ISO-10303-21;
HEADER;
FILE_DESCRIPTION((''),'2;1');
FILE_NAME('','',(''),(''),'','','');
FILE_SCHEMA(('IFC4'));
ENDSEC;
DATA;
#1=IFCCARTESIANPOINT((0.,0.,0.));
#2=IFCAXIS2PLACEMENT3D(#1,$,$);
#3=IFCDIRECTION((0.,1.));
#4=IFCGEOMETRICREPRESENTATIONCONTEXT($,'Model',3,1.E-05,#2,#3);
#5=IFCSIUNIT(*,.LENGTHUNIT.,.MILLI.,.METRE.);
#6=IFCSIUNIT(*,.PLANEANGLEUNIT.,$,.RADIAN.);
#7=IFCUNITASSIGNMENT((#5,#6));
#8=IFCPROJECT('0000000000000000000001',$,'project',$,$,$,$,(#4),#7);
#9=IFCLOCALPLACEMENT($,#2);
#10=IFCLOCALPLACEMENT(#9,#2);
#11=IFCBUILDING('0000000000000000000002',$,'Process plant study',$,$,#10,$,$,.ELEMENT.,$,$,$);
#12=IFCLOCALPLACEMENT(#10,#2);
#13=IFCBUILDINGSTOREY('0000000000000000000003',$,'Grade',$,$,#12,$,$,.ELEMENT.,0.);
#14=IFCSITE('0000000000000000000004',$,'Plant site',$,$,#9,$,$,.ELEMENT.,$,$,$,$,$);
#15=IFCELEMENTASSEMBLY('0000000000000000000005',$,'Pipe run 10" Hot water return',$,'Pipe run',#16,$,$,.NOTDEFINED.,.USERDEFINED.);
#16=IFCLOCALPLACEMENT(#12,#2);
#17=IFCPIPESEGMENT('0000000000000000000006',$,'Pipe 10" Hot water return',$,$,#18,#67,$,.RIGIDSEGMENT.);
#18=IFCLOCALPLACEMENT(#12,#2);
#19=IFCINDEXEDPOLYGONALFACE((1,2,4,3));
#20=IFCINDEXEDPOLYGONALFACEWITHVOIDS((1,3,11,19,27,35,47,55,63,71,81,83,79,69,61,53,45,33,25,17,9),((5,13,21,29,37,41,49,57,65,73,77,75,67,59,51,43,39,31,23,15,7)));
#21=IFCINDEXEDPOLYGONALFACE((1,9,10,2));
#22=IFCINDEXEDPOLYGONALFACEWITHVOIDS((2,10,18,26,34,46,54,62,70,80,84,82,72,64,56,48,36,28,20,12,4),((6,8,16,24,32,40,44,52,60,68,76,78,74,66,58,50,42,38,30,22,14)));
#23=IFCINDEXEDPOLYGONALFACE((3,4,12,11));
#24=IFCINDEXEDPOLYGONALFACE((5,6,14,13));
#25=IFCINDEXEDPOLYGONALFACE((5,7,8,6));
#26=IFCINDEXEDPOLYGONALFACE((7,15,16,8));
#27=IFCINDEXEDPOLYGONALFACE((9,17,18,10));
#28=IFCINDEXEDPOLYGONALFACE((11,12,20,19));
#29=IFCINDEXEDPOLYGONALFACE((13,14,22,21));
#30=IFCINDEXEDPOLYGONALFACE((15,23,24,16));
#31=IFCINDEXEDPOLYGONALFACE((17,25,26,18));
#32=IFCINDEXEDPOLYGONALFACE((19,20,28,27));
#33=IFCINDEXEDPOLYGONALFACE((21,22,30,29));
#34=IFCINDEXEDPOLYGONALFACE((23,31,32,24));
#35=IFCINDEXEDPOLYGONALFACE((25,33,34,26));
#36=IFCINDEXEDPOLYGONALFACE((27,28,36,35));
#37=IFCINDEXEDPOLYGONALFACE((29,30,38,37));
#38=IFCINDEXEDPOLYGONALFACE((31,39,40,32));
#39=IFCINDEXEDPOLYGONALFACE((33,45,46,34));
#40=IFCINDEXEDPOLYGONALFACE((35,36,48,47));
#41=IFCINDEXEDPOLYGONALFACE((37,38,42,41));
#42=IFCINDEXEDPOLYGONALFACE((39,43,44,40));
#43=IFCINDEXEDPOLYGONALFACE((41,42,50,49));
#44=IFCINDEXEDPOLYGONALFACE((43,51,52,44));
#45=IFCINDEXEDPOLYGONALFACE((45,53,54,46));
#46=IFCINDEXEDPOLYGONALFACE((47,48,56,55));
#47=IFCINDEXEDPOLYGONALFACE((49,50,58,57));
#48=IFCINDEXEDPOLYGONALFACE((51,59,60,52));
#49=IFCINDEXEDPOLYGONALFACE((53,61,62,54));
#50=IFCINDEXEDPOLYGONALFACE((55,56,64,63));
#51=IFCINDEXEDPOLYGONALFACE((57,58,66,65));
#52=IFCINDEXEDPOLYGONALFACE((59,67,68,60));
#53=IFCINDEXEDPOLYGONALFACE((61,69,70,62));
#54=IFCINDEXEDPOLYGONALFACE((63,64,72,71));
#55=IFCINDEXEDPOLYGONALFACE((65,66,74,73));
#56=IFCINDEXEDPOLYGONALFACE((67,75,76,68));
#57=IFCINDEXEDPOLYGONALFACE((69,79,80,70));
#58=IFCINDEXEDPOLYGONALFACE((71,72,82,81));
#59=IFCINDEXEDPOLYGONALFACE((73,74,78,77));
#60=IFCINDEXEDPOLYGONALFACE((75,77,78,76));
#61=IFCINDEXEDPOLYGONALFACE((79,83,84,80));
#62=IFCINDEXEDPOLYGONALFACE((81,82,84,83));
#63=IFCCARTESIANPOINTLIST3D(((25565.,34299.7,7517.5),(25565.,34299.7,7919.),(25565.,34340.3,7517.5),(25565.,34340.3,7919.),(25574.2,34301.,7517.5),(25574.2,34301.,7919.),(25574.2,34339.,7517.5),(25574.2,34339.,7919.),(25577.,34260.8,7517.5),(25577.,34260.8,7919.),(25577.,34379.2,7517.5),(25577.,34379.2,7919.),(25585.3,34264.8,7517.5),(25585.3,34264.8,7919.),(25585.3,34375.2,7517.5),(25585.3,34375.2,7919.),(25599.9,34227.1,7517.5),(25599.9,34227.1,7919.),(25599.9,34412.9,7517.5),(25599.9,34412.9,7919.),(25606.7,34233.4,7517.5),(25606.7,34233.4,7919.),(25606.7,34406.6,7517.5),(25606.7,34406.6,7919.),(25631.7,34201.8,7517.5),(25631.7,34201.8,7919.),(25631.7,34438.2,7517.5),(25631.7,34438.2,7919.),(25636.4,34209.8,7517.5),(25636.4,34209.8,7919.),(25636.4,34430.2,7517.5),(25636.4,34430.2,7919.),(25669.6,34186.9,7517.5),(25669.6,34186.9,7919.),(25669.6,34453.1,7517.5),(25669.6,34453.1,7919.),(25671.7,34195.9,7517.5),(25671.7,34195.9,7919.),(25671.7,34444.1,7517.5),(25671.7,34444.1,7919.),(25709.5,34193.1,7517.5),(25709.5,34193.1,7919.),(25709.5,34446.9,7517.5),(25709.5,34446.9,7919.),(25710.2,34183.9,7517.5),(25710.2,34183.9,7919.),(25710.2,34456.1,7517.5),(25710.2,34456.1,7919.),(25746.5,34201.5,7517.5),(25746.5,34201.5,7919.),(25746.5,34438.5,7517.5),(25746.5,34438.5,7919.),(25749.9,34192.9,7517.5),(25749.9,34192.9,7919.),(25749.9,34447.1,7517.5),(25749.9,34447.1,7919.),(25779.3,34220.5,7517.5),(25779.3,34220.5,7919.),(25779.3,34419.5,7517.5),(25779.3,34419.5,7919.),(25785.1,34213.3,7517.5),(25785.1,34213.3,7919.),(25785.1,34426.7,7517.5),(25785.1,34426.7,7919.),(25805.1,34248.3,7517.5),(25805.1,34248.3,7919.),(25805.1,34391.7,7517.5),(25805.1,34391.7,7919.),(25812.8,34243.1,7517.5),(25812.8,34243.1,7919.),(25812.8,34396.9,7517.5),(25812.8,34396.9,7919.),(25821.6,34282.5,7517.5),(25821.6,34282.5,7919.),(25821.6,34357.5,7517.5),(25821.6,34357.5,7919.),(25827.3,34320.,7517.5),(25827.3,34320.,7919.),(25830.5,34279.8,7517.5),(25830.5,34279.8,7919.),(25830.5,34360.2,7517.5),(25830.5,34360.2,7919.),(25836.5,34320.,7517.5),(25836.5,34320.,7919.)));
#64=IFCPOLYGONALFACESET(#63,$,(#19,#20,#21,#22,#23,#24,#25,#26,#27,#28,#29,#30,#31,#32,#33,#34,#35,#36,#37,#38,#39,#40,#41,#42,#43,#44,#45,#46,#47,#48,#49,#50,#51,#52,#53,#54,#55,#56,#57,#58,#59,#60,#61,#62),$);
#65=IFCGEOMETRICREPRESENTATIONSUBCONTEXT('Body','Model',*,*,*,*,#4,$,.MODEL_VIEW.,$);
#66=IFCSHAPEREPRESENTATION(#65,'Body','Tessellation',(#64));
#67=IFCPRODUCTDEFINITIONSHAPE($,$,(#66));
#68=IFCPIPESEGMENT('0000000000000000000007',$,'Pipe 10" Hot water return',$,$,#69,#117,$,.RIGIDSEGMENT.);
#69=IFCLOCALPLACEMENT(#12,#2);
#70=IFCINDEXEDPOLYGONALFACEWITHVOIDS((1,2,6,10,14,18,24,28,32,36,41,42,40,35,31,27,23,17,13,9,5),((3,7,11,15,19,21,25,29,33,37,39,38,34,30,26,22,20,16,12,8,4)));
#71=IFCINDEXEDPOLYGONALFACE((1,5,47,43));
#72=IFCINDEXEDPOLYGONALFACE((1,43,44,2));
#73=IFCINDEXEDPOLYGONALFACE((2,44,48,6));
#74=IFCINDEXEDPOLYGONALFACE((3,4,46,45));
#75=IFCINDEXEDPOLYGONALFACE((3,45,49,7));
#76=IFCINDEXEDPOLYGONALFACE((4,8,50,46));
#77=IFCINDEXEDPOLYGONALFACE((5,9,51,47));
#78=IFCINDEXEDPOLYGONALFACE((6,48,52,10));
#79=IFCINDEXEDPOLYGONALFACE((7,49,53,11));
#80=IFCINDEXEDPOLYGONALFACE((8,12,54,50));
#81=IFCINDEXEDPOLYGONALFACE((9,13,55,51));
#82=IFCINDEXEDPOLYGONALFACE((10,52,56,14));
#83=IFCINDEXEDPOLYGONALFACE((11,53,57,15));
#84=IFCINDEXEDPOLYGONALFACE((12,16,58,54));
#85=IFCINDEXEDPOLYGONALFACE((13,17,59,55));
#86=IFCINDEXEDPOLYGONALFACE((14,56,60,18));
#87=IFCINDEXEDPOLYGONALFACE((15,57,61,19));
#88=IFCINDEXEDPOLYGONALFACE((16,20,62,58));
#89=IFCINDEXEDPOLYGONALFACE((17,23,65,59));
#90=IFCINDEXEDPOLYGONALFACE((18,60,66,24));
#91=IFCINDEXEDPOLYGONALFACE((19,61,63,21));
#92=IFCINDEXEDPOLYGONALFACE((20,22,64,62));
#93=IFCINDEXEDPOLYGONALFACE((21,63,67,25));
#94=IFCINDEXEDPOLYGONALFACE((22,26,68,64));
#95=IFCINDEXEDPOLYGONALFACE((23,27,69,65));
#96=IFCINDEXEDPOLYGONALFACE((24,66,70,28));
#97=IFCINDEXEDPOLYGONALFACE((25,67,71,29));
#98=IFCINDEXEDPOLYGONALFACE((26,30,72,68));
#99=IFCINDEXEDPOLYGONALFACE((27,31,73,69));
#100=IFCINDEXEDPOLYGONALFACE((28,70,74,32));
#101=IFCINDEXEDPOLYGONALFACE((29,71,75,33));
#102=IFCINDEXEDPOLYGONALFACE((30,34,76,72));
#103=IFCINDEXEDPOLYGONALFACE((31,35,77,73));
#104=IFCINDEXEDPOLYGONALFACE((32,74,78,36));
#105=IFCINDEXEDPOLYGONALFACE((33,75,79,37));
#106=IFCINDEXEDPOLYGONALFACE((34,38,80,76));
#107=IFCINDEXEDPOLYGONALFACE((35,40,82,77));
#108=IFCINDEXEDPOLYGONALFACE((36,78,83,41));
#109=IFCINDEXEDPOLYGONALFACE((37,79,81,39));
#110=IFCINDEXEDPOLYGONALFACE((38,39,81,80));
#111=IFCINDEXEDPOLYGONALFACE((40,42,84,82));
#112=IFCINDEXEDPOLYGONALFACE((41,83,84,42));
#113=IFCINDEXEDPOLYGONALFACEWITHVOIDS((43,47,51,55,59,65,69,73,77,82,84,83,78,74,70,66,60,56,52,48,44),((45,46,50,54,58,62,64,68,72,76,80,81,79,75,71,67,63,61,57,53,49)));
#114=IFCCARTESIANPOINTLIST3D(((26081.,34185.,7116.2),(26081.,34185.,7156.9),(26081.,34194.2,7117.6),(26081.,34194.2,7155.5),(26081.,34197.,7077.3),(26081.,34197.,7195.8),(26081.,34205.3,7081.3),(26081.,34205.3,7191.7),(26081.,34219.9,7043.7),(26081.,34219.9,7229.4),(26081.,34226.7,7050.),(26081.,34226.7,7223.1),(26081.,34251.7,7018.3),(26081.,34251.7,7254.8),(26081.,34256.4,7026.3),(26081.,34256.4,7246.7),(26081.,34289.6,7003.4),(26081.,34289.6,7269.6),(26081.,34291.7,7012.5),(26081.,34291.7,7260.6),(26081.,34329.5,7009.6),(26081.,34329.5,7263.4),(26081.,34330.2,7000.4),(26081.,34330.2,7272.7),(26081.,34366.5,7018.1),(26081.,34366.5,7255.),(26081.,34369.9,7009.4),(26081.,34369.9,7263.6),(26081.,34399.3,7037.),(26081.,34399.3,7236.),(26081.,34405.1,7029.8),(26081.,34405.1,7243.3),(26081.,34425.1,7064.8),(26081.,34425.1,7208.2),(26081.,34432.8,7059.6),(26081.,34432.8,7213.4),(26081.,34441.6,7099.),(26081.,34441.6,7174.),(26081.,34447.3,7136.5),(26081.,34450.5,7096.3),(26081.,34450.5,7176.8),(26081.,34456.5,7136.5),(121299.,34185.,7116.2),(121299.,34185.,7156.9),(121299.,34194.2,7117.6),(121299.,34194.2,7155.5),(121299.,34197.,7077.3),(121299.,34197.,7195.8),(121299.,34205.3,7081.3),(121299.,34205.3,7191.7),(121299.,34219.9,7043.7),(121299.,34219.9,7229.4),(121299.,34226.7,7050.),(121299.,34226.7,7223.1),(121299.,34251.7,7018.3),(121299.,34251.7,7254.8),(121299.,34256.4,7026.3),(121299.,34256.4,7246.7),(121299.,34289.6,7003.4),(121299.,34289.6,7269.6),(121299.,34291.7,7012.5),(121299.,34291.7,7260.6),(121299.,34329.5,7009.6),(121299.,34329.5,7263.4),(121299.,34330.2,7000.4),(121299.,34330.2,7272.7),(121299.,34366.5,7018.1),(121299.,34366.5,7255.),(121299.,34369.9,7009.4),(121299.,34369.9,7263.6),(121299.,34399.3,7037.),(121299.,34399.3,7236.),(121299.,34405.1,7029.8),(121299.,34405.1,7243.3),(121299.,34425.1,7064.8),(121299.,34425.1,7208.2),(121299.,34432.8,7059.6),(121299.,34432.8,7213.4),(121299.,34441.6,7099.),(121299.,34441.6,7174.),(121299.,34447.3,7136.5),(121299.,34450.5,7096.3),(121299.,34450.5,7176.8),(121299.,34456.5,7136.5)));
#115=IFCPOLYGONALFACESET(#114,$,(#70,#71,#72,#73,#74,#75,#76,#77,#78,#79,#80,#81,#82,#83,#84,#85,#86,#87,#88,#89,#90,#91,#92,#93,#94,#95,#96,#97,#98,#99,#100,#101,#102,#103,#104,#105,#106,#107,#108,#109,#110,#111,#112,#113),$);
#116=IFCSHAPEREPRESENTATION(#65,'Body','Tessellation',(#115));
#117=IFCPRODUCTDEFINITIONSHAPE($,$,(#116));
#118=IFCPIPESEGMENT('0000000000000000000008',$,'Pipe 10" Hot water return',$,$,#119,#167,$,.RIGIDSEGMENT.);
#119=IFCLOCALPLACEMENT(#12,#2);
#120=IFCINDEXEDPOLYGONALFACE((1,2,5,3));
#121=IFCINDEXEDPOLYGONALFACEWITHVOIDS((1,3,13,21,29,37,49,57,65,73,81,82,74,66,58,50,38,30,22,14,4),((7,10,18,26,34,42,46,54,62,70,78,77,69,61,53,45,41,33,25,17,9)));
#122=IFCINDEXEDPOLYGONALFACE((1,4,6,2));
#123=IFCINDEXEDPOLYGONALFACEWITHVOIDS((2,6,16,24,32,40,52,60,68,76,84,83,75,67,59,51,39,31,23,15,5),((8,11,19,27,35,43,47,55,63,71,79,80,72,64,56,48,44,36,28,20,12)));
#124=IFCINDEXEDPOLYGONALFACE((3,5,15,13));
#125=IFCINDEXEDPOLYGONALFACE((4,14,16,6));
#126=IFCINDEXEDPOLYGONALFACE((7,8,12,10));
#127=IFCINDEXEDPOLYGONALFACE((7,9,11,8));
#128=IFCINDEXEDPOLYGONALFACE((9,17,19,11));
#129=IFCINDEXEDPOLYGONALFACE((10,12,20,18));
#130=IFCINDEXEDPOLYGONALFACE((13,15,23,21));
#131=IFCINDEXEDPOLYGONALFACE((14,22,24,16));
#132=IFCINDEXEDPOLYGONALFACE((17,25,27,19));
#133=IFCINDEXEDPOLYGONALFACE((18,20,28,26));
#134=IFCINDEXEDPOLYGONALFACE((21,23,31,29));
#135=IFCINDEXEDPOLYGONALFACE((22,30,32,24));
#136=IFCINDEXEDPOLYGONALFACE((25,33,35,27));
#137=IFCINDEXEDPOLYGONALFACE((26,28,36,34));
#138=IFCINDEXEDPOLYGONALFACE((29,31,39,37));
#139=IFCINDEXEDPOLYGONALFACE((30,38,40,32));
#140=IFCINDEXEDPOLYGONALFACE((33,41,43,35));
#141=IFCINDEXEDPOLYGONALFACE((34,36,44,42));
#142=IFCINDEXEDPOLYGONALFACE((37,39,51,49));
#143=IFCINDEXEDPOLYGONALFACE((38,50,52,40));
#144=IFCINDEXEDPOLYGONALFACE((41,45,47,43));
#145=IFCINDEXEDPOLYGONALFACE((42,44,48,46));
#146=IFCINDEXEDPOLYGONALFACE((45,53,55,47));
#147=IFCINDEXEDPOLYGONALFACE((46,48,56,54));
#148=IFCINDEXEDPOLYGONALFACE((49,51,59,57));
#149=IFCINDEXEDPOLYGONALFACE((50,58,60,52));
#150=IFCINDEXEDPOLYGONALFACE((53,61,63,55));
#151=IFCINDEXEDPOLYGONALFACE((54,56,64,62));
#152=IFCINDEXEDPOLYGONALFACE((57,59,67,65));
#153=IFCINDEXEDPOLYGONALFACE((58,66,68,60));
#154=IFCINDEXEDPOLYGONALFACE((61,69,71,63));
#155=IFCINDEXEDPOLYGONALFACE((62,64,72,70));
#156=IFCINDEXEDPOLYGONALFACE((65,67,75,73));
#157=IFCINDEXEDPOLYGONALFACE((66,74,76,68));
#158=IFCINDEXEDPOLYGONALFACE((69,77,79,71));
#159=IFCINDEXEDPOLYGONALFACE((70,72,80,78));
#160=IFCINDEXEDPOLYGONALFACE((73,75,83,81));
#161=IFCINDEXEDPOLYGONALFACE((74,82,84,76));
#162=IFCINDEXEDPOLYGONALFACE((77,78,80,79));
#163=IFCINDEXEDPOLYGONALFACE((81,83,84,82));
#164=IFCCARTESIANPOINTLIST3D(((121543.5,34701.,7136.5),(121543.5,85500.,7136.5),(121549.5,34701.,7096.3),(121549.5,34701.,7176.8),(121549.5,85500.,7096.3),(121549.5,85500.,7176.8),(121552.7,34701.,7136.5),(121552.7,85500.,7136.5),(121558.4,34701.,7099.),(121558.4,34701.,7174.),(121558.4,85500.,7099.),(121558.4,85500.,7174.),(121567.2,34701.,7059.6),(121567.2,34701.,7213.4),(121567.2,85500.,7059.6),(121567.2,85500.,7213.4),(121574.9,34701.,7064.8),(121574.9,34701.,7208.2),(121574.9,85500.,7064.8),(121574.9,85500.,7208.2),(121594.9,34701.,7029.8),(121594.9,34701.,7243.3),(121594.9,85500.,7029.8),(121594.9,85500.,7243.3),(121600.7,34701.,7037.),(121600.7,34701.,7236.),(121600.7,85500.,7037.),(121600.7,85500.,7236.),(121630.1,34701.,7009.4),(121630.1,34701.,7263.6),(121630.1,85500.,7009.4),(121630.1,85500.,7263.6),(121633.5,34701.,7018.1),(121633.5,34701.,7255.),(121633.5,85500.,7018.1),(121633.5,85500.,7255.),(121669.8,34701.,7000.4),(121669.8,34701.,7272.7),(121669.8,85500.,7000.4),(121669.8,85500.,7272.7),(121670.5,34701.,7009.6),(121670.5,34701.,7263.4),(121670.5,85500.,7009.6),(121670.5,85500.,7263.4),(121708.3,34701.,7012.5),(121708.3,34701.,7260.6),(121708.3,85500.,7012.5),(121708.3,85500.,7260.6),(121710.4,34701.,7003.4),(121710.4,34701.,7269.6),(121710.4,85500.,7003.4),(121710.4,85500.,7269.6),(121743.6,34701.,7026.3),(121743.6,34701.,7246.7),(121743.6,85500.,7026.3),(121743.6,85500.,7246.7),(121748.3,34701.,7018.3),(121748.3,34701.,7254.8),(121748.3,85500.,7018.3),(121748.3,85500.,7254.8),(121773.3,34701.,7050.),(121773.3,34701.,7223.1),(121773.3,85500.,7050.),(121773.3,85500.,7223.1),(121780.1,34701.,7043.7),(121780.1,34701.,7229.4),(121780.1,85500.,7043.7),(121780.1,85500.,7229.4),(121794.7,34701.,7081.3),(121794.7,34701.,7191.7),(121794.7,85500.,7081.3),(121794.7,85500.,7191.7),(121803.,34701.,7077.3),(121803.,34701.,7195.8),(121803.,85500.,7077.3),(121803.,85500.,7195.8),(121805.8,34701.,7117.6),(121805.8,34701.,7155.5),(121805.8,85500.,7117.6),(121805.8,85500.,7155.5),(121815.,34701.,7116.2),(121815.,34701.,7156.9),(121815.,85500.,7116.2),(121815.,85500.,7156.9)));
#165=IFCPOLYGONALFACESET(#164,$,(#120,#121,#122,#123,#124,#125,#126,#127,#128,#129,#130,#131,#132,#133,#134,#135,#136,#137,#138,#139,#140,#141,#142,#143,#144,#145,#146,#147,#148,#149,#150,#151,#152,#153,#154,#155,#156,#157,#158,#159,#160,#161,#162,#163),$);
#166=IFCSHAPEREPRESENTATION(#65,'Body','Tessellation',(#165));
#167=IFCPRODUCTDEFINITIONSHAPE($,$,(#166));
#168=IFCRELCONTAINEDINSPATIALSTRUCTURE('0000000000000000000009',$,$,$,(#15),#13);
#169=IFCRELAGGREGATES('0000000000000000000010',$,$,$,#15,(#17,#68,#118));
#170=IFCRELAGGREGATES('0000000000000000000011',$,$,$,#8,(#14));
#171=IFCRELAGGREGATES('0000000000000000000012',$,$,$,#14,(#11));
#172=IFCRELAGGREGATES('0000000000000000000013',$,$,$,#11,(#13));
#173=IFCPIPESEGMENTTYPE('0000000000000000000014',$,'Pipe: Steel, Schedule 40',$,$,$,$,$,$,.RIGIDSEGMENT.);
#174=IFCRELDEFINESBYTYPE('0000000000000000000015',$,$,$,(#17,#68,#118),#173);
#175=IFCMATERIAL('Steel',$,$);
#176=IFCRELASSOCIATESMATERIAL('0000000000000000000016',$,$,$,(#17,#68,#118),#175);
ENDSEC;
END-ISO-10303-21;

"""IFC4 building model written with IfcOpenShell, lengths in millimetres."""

from ifc_helpers import new_model, si_unit, direction, frame, origin, origin_with_axes, origin_2d, place, context, subcontext, project, spatial, hollow_circle, extrude, material, type_object, element, aggregate, save


model = new_model("IFC4")

# Units and contexts
model_context = context("Model", 3, precision=1e-05, world=origin(), true_north=direction((0.0, 1.0)))
body_context = subcontext(model_context, "Body", "Model", "MODEL_VIEW")
ifc_project = project(units=[si_unit("LENGTHUNIT", "METRE", prefix="MILLI"), si_unit("PLANEANGLEUNIT", "RADIAN")], contexts=[model_context])

# Site, building, storey
site_placement = place(None, origin())
site = spatial("IfcSite", under=ifc_project, at=site_placement, Name="Plant site", CompositionType="ELEMENT")
building_placement = place(site_placement, origin())
building = spatial("IfcBuilding", under=site, at=building_placement, Name="Process plant study", CompositionType="ELEMENT")
storey_placement = place(building_placement, origin())
storey = spatial("IfcBuildingStorey", under=building, at=storey_placement, Name="Grade", CompositionType="ELEMENT", Elevation=0.0)

# Shared definitions
ifc_material = material(Name="Steel")
pipe_segment_type = type_object("IfcPipeSegmentType", Name="Pipe: Steel, Schedule 40", PredefinedType="RIGIDSEGMENT")

# Element assembly, pipe segments
assembly_1_placement = place(storey_placement, origin_with_axes())
assembly_1 = element("IfcElementAssembly", 1, at=assembly_1_placement, inside=storey, Name="Pipe run 10\" Hot water return", ObjectType="Pipe run", AssemblyPlace="NOTDEFINED", PredefinedType="USERDEFINED")
pipe_segment_1_placement = place(storey_placement, origin_with_axes())
pipe_segment_1 = element("IfcPipeSegment", 2, at=pipe_segment_1_placement, type_object=pipe_segment_type, material=ifc_material, Name="Pipe 10\" Hot water return", PredefinedType="RIGIDSEGMENT", context=body_context, shape_type="SweptSolid", body=[
    extrude(hollow_circle(Radius=136.5, WallThickness=9.3, at=origin_2d()), frame((25700.0, 34320.0, 7919.0), z_axis=(0.0, 0.0, -1.0), x_axis=(1.0, 0.0, 0.0)), (0.0, 0.0, 1.0), 401.5),
])
pipe_segment_2_placement = place(storey_placement, origin_with_axes())
pipe_segment_2 = element("IfcPipeSegment", 3, at=pipe_segment_2_placement, type_object=pipe_segment_type, material=ifc_material, Name="Pipe 10\" Hot water return", PredefinedType="RIGIDSEGMENT", context=body_context, shape_type="SweptSolid", body=[
    extrude(hollow_circle(Radius=136.5, WallThickness=9.3, at=origin_2d()), frame((26081.0, 34320.0, 7136.5), z_axis=(1.0, 0.0, 0.0), x_axis=(0.0, 1.0, 0.0)), (0.0, 0.0, 1.0), 95218.0),
])
pipe_segment_3_placement = place(storey_placement, origin_with_axes())
pipe_segment_3 = element("IfcPipeSegment", 4, at=pipe_segment_3_placement, type_object=pipe_segment_type, material=ifc_material, Name="Pipe 10\" Hot water return", PredefinedType="RIGIDSEGMENT", context=body_context, shape_type="SweptSolid", body=[
    extrude(hollow_circle(Radius=136.5, WallThickness=9.3, at=origin_2d()), frame((121680.0, 34701.0, 7136.5), z_axis=(0.0, 1.0, 0.0), x_axis=(-1.0, 0.0, 0.0)), (0.0, 0.0, 1.0), 50799.0),
])

aggregate(assembly_1, [pipe_segment_1, pipe_segment_2, pipe_segment_3])

save(model, "model.ifc")
